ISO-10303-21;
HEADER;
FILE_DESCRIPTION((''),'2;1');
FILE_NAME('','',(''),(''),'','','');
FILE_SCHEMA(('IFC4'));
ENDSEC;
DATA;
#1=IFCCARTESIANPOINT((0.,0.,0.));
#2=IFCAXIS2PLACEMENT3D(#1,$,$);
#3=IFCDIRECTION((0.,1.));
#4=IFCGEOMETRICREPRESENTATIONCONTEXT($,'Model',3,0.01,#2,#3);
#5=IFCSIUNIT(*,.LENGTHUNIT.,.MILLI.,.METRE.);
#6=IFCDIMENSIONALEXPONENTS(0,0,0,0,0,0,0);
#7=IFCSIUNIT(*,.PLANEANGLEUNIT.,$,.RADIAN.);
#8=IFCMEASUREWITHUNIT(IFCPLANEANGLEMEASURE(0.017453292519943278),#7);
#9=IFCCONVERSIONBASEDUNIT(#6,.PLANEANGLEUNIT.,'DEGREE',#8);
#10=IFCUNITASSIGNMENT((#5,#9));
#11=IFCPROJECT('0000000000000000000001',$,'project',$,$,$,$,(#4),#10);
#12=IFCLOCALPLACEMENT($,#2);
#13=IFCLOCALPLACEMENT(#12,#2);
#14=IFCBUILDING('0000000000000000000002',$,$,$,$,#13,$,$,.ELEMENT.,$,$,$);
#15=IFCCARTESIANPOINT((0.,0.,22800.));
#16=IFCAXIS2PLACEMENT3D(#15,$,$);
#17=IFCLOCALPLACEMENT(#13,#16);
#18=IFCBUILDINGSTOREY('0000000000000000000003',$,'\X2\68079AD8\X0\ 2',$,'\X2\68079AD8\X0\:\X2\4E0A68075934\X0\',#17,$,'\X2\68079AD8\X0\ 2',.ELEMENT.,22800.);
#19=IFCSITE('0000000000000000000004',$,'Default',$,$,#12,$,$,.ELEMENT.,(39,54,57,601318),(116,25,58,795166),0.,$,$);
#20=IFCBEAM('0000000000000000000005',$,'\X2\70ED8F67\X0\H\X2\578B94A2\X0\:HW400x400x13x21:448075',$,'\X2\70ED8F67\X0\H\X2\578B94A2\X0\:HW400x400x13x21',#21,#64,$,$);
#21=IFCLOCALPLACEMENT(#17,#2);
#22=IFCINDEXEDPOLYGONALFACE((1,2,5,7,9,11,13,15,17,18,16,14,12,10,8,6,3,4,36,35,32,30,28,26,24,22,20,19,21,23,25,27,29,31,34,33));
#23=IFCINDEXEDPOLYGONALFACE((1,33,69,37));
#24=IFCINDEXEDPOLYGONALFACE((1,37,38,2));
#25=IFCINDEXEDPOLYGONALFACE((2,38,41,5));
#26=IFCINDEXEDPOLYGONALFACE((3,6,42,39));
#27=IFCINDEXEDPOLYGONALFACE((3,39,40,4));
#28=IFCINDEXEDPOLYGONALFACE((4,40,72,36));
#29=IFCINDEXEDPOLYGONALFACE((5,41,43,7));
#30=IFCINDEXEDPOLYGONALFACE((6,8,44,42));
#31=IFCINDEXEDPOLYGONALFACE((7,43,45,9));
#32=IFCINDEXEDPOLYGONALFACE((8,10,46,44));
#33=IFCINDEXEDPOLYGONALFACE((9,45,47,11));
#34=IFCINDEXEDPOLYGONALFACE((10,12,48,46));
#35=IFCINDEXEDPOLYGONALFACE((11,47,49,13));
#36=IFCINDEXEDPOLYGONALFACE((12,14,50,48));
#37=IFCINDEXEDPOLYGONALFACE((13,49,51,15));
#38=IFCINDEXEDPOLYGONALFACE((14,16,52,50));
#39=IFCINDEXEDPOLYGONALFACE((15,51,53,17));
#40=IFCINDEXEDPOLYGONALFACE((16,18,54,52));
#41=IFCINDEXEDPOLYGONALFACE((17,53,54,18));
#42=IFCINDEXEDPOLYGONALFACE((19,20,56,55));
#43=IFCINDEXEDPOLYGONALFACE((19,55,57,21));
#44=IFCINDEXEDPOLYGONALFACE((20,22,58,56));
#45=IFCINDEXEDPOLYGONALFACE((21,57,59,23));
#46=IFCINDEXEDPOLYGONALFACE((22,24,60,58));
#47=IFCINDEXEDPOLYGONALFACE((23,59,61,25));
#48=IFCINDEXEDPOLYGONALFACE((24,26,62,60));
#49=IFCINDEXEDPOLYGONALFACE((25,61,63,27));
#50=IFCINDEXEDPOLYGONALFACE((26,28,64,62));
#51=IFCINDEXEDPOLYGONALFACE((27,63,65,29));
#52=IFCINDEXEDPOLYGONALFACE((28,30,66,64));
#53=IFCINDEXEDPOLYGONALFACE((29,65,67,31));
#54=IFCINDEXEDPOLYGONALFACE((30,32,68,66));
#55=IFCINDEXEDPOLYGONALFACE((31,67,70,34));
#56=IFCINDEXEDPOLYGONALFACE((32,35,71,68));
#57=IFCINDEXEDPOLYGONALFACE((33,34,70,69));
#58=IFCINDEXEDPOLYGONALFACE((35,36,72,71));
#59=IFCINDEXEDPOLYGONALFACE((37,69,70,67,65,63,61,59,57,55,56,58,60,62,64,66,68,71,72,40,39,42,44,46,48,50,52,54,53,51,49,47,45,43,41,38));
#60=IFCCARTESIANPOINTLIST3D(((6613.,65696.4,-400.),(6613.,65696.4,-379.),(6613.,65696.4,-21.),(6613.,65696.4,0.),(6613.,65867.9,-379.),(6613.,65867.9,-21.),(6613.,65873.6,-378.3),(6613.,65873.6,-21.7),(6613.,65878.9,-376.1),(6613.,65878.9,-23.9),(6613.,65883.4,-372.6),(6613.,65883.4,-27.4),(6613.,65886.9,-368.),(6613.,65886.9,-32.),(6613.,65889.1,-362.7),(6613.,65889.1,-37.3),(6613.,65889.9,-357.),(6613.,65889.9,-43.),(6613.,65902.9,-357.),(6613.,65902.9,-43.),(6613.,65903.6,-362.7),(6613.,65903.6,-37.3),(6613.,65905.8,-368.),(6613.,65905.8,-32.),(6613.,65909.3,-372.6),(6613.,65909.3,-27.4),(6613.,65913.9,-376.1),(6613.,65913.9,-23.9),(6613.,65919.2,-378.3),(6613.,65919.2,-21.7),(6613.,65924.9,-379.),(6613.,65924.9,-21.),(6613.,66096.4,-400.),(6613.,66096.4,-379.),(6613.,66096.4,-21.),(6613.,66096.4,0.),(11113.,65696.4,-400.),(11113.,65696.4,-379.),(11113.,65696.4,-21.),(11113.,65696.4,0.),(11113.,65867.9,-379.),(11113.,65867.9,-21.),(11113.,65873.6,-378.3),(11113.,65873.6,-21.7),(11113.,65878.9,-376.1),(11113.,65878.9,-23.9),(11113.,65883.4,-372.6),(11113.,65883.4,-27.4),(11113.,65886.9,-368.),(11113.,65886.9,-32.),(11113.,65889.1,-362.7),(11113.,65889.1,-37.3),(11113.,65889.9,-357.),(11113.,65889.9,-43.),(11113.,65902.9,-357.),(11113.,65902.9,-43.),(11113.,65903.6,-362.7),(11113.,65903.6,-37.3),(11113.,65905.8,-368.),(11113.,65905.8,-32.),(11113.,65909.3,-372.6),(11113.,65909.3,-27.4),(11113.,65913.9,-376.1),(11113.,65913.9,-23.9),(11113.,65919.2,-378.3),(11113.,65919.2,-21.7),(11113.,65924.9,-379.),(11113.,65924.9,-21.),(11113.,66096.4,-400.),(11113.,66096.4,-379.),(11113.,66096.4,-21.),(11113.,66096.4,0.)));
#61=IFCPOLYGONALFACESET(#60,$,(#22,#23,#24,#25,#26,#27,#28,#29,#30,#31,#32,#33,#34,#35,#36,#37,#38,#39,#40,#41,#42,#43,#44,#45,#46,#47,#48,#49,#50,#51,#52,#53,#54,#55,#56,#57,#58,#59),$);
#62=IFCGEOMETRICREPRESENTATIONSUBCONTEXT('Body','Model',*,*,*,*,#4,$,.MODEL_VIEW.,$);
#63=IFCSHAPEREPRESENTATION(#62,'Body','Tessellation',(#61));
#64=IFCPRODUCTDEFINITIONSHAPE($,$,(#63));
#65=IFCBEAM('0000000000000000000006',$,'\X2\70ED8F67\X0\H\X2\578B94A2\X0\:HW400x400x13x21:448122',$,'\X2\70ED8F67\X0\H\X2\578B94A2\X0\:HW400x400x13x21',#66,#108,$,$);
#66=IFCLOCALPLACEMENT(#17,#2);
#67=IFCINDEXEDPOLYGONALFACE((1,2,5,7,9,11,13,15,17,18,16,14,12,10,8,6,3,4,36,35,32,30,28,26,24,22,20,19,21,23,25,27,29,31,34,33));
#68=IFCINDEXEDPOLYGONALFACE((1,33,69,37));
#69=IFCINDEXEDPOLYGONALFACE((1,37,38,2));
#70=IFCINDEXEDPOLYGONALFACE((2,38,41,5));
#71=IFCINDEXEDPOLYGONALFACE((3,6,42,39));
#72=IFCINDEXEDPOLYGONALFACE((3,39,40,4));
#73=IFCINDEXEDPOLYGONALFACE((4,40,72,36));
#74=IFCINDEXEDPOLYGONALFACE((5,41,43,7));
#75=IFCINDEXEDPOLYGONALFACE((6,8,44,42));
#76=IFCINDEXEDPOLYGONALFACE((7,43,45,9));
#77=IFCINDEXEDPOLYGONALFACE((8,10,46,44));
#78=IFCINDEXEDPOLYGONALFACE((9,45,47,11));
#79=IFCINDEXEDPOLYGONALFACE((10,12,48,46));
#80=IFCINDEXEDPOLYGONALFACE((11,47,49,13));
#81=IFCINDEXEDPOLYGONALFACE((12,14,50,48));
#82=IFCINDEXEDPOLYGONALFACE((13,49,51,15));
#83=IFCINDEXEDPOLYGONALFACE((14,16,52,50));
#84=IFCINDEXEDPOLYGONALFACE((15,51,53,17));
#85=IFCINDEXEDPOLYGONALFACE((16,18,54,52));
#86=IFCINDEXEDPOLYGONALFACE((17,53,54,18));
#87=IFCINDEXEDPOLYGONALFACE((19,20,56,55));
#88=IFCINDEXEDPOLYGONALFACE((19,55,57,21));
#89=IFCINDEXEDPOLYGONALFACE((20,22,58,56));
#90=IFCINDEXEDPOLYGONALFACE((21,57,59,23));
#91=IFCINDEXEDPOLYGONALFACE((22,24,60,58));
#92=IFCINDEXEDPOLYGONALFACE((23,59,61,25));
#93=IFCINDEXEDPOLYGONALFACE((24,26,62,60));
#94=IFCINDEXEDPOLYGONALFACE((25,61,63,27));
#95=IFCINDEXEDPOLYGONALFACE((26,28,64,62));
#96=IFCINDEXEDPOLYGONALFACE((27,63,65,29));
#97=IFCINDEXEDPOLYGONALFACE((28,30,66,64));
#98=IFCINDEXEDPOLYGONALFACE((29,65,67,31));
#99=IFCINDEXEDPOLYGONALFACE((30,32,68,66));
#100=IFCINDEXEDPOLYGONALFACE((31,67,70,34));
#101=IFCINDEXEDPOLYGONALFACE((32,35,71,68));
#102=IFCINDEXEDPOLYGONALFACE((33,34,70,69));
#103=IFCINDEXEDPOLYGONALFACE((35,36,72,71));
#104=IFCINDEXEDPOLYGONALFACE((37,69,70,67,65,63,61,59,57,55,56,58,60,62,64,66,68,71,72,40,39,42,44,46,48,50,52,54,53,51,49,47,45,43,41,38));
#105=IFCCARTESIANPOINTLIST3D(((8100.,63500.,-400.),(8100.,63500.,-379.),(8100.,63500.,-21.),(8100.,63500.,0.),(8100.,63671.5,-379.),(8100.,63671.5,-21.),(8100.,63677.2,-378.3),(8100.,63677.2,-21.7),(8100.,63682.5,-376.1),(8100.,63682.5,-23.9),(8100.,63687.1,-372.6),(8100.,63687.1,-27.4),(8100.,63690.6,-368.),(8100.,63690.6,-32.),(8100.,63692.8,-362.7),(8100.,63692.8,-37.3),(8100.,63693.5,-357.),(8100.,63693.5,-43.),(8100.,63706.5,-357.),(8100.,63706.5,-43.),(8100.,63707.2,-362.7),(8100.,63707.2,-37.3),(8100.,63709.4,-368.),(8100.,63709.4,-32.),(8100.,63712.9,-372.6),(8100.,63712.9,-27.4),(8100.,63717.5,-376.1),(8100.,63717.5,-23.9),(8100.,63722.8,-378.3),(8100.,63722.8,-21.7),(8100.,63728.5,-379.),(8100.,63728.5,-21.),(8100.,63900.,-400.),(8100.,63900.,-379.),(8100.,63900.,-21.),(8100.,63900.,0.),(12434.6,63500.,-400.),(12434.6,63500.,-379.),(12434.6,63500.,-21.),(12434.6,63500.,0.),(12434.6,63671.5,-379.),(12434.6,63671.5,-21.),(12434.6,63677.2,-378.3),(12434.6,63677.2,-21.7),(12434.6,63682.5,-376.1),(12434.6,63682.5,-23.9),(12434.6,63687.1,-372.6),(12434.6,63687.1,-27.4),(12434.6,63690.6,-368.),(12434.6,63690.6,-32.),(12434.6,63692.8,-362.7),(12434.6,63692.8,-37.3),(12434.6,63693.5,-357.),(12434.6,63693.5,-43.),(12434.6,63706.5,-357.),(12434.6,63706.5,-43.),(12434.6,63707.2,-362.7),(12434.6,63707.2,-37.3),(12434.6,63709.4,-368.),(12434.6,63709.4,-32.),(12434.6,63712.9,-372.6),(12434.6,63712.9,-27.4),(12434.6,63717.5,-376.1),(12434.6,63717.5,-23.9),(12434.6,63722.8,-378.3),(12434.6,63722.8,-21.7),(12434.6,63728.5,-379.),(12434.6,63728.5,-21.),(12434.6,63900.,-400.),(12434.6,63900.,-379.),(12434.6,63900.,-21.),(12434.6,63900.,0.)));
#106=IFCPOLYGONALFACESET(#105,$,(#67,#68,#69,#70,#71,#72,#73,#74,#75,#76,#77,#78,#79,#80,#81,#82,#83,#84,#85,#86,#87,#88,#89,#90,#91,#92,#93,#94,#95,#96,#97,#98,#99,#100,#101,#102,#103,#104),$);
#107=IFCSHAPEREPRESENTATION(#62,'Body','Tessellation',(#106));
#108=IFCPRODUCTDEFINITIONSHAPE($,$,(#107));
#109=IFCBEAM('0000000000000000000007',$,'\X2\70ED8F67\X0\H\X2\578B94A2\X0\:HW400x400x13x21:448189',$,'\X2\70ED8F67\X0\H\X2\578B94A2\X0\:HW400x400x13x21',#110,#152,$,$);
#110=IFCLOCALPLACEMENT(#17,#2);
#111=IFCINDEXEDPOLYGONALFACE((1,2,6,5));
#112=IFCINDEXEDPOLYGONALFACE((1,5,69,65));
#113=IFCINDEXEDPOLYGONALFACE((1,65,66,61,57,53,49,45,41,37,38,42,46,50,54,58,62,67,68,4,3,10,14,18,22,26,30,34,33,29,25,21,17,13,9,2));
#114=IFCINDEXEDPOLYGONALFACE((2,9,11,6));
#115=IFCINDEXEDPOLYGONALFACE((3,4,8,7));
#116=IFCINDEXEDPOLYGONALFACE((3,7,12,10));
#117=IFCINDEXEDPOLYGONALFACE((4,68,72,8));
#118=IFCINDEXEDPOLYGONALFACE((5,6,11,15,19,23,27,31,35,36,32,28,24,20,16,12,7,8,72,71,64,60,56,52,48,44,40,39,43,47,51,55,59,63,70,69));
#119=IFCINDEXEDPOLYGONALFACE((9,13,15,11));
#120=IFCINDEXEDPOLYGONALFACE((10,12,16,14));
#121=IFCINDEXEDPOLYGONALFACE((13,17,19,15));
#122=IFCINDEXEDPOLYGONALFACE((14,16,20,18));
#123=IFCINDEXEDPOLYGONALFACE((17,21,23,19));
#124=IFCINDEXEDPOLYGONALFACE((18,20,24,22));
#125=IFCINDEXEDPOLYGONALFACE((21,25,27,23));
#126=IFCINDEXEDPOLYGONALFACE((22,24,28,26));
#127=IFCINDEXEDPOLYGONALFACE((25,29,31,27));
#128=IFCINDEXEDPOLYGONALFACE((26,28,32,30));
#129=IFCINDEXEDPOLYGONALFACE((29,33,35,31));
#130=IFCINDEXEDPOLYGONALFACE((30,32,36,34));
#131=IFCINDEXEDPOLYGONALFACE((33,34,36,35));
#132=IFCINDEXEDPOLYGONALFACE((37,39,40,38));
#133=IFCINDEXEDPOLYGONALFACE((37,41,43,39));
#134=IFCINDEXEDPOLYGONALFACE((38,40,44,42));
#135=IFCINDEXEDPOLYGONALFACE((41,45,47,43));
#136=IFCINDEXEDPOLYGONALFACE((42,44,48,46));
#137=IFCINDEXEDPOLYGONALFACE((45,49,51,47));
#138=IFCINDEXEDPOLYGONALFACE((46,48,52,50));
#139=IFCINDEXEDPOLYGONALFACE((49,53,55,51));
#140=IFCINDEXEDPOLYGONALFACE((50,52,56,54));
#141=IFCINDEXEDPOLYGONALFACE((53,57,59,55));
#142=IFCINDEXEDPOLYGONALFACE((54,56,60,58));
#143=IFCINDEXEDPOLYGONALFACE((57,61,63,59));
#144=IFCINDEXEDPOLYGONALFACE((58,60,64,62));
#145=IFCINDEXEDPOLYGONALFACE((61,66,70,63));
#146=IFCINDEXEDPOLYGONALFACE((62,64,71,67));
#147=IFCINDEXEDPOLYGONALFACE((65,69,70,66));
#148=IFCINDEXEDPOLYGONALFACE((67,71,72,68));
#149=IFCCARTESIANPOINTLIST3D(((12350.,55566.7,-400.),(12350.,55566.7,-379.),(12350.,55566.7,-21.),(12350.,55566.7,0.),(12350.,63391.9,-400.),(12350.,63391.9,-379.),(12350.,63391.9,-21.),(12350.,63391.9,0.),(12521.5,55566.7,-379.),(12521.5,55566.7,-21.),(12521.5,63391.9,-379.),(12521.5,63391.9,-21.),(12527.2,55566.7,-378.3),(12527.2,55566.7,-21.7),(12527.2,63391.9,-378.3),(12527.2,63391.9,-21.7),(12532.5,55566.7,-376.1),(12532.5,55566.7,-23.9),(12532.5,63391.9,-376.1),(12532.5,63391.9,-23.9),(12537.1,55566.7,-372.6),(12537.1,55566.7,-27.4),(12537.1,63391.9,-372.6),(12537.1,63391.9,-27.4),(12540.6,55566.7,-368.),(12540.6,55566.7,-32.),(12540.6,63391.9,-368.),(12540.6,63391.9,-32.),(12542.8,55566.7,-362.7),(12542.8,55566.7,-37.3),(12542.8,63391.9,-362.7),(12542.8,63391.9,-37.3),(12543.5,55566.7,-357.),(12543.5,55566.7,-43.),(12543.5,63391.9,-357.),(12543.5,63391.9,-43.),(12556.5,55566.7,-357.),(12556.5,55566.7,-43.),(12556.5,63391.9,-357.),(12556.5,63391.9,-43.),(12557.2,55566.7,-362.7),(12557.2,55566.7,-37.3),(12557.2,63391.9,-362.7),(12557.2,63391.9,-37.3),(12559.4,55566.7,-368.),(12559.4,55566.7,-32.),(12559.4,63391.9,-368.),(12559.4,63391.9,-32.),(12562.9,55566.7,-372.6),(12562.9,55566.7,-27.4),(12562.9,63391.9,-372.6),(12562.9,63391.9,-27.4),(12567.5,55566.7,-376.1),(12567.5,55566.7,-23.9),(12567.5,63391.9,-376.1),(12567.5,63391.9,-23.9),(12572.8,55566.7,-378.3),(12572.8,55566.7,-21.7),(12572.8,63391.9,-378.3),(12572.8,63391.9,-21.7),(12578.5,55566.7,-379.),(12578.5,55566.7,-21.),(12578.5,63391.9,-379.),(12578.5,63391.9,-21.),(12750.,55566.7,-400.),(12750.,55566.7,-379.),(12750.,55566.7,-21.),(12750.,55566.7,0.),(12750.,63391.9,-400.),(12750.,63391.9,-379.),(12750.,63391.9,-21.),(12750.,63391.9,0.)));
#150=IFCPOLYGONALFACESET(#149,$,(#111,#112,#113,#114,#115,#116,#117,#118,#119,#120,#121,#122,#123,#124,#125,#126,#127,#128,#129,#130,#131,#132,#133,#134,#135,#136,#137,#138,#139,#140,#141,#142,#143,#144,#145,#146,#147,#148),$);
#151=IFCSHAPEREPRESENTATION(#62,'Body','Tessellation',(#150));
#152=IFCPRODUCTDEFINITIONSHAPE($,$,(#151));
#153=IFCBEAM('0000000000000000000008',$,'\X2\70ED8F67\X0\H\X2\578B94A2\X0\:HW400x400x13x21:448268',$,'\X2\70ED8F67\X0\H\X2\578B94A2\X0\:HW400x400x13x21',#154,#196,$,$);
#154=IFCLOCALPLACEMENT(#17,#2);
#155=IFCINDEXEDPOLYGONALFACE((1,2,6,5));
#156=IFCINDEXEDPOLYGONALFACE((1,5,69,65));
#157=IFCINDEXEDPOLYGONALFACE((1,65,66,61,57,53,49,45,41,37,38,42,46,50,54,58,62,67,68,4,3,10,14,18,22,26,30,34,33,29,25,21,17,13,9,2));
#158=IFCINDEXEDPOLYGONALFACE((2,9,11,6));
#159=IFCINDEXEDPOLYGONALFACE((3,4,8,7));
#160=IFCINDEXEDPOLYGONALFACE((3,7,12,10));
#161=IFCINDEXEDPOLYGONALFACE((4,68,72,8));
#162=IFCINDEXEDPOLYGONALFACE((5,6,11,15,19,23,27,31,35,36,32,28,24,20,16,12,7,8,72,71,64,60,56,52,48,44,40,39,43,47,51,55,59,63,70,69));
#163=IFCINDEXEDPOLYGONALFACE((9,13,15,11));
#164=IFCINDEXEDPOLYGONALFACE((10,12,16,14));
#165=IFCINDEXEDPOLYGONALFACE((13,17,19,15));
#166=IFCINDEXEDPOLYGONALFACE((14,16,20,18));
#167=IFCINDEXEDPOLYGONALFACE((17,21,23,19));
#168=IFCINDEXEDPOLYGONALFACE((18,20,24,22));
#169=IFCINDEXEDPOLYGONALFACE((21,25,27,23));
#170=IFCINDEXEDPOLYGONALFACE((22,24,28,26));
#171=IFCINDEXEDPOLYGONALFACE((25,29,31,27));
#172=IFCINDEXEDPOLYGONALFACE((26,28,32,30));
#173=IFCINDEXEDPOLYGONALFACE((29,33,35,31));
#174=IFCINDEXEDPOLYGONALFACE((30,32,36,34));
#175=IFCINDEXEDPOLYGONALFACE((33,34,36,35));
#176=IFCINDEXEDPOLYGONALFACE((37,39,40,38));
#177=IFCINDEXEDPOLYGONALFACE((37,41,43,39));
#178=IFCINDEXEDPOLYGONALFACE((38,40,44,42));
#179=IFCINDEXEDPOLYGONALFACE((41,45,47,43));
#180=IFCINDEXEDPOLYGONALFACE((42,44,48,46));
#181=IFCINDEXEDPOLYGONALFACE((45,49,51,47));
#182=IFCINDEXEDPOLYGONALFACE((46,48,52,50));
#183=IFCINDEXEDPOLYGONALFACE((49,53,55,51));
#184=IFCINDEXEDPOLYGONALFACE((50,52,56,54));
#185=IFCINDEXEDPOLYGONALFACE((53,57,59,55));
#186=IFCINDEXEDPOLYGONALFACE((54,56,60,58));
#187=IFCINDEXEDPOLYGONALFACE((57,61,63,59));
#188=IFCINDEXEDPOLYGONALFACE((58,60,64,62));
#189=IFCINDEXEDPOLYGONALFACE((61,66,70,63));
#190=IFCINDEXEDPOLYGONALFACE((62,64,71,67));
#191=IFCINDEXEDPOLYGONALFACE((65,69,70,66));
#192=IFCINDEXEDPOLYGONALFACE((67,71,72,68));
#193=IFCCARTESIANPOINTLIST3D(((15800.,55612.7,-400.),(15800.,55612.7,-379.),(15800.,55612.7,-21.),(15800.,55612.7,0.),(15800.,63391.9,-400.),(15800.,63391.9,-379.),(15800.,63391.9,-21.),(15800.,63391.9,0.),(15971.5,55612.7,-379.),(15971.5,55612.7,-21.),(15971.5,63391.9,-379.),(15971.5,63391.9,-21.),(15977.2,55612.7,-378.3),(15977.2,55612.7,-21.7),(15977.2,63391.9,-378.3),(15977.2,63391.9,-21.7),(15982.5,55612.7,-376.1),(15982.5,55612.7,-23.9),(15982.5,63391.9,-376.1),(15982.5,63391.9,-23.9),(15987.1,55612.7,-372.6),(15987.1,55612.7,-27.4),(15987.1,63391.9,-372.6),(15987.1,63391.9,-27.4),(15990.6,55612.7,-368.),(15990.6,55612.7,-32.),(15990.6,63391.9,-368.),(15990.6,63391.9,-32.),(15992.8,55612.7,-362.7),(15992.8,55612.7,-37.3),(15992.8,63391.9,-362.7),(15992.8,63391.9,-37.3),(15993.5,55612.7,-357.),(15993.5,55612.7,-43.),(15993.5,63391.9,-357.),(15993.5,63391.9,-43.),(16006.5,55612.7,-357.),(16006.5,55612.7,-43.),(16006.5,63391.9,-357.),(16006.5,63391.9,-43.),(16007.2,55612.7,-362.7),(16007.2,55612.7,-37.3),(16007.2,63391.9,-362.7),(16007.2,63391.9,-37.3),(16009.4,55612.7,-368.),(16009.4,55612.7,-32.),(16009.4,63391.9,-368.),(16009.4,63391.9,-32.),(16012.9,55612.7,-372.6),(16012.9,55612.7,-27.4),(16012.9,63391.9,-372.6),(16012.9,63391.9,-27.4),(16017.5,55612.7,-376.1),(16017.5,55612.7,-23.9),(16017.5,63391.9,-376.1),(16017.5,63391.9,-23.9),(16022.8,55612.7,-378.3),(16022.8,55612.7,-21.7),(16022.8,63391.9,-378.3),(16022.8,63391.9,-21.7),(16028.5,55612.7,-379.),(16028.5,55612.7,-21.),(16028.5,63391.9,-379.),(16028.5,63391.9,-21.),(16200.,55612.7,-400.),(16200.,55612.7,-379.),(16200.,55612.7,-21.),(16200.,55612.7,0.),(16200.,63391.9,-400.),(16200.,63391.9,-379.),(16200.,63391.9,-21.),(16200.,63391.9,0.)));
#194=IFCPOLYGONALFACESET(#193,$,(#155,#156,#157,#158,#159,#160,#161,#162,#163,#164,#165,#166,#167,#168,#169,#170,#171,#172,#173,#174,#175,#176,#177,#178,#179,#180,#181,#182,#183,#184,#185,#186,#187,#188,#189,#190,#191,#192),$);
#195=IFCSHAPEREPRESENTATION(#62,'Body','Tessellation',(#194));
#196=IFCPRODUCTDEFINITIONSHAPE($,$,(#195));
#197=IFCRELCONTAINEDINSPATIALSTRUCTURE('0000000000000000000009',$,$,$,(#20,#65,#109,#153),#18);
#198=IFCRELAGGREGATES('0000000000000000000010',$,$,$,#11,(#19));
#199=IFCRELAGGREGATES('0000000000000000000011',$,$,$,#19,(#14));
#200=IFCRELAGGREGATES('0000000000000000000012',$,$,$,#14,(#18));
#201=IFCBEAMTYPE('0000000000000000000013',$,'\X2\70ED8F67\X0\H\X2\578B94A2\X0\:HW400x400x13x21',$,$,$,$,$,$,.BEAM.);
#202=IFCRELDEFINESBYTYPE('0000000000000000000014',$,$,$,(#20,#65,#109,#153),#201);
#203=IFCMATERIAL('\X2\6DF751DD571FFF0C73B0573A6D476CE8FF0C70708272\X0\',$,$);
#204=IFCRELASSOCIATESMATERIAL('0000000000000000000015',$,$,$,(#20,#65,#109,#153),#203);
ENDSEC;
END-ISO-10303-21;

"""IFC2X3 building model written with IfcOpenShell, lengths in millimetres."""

from ifc_helpers import new_model, entity, si_unit, converted_unit, direction, frame, frame_2d, origin, place, context, subcontext, project, spatial, i_section, extrude, material, type_object, element, save


model = new_model("IFC2X3")

# Units and contexts
model_context = context("Model", 3, precision=0.01, world=origin(), true_north=direction((0.0, 1.0)))
body_context = subcontext(model_context, "Body", "Model", "MODEL_VIEW")
ifc_project = project(units=[si_unit("LENGTHUNIT", "METRE", prefix="MILLI"), converted_unit("PLANEANGLEUNIT", "DEGREE", entity("IfcPlaneAngleMeasure", 0.017453292519943278), si_unit("PLANEANGLEUNIT", "RADIAN"), dimensions=[0, 0, 0, 0, 0, 0, 0])], contexts=[model_context])

# Site, building, storey
site_placement = place(None, origin())
site = spatial("IfcSite", under=ifc_project, at=site_placement, Name="Default", CompositionType="ELEMENT", RefLatitude=(39, 54, 57, 601318), RefLongitude=(116, 25, 58, 795166), RefElevation=0.0)
building_placement = place(site_placement, origin())
building = spatial("IfcBuilding", under=site, at=building_placement, CompositionType="ELEMENT")
storey_placement = place(building_placement, frame((0.0, 0.0, 22800.0)))
storey = spatial("IfcBuildingStorey", under=building, at=storey_placement, Name="标高 2", ObjectType="标高:上标头", LongName="标高 2", CompositionType="ELEMENT", Elevation=22800.0)

# Beams
ifc_material = material(Name="混凝土，现场浇注，灰色")
beam_type = type_object("IfcBeamType", Name="热轧H型钢:HW400x400x13x21", PredefinedType="BEAM")
beam_1_placement = place(storey_placement, frame((6613.0, 65896.4, 0.0)))
element("IfcBeam", 1, at=beam_1_placement, inside=storey, type_object=beam_type, material=ifc_material, Name="热轧H型钢:HW400x400x13x21:448075", ObjectType="热轧H型钢:HW400x400x13x21", context=body_context, shape_type="SweptSolid", body=[
    extrude(i_section(OverallWidth=400.0, OverallDepth=400.0, WebThickness=13.0, FlangeThickness=21.0, FilletRadius=22.0, at=frame_2d((0.0, 0.0), x_axis=(0.0, 1.0))), frame((0.0, 0.0, -200.0), z_axis=(1.0, 0.0, 0.0), x_axis=(0.0, 0.0, -1.0)), (0.0, 0.0, 1.0), 4500.0),
])
beam_2_placement = place(storey_placement, frame((12550.0, 63700.0, 0.0), z_axis=(0.0, 0.0, 1.0), x_axis=(-1.0, 0.0, 0.0)))
element("IfcBeam", 2, at=beam_2_placement, inside=storey, type_object=beam_type, material=ifc_material, Name="热轧H型钢:HW400x400x13x21:448122", ObjectType="热轧H型钢:HW400x400x13x21", context=body_context, shape_type="SweptSolid", body=[
    extrude(i_section(OverallWidth=400.0, OverallDepth=400.0, WebThickness=13.0, FlangeThickness=21.0, FilletRadius=22.0, at=frame_2d((0.0, 0.0), x_axis=(0.0, 1.0))), frame((115.4, 0.0, -200.0), z_axis=(1.0, 0.0, 0.0), x_axis=(0.0, 0.0, -1.0)), (0.0, 0.0, 1.0), 4334.6),
])
beam_3_placement = place(storey_placement, frame((12550.0, 55400.0, 0.0), z_axis=(0.0, 0.0, 1.0), x_axis=(0.0, 1.0, 0.0)))
element("IfcBeam", 3, at=beam_3_placement, inside=storey, type_object=beam_type, material=ifc_material, Name="热轧H型钢:HW400x400x13x21:448189", ObjectType="热轧H型钢:HW400x400x13x21", context=body_context, shape_type="SweptSolid", body=[
    extrude(i_section(OverallWidth=400.0, OverallDepth=400.0, WebThickness=13.0, FlangeThickness=21.0, FilletRadius=22.0, at=frame_2d((0.0, 0.0), x_axis=(0.0, 1.0))), frame((166.7, 0.0, -200.0), z_axis=(1.0, 0.0, 0.0), x_axis=(0.0, 0.0, -1.0)), (0.0, 0.0, 1.0), 7825.2),
])
beam_4_placement = place(storey_placement, frame((16000.0, 63700.0, 0.0), z_axis=(0.0, 0.0, 1.0), x_axis=(0.0, -1.0, 0.0)))
element("IfcBeam", 4, at=beam_4_placement, inside=storey, type_object=beam_type, material=ifc_material, Name="热轧H型钢:HW400x400x13x21:448268", ObjectType="热轧H型钢:HW400x400x13x21", context=body_context, shape_type="SweptSolid", body=[
    extrude(i_section(OverallWidth=400.0, OverallDepth=400.0, WebThickness=13.0, FlangeThickness=21.0, FilletRadius=22.0, at=frame_2d((0.0, 0.0), x_axis=(0.0, 1.0))), frame((308.1, 0.0, -200.0), z_axis=(1.0, 0.0, 0.0), x_axis=(0.0, 0.0, -1.0)), (0.0, 0.0, 1.0), 7779.2),
])

save(model, "model.ifc")
